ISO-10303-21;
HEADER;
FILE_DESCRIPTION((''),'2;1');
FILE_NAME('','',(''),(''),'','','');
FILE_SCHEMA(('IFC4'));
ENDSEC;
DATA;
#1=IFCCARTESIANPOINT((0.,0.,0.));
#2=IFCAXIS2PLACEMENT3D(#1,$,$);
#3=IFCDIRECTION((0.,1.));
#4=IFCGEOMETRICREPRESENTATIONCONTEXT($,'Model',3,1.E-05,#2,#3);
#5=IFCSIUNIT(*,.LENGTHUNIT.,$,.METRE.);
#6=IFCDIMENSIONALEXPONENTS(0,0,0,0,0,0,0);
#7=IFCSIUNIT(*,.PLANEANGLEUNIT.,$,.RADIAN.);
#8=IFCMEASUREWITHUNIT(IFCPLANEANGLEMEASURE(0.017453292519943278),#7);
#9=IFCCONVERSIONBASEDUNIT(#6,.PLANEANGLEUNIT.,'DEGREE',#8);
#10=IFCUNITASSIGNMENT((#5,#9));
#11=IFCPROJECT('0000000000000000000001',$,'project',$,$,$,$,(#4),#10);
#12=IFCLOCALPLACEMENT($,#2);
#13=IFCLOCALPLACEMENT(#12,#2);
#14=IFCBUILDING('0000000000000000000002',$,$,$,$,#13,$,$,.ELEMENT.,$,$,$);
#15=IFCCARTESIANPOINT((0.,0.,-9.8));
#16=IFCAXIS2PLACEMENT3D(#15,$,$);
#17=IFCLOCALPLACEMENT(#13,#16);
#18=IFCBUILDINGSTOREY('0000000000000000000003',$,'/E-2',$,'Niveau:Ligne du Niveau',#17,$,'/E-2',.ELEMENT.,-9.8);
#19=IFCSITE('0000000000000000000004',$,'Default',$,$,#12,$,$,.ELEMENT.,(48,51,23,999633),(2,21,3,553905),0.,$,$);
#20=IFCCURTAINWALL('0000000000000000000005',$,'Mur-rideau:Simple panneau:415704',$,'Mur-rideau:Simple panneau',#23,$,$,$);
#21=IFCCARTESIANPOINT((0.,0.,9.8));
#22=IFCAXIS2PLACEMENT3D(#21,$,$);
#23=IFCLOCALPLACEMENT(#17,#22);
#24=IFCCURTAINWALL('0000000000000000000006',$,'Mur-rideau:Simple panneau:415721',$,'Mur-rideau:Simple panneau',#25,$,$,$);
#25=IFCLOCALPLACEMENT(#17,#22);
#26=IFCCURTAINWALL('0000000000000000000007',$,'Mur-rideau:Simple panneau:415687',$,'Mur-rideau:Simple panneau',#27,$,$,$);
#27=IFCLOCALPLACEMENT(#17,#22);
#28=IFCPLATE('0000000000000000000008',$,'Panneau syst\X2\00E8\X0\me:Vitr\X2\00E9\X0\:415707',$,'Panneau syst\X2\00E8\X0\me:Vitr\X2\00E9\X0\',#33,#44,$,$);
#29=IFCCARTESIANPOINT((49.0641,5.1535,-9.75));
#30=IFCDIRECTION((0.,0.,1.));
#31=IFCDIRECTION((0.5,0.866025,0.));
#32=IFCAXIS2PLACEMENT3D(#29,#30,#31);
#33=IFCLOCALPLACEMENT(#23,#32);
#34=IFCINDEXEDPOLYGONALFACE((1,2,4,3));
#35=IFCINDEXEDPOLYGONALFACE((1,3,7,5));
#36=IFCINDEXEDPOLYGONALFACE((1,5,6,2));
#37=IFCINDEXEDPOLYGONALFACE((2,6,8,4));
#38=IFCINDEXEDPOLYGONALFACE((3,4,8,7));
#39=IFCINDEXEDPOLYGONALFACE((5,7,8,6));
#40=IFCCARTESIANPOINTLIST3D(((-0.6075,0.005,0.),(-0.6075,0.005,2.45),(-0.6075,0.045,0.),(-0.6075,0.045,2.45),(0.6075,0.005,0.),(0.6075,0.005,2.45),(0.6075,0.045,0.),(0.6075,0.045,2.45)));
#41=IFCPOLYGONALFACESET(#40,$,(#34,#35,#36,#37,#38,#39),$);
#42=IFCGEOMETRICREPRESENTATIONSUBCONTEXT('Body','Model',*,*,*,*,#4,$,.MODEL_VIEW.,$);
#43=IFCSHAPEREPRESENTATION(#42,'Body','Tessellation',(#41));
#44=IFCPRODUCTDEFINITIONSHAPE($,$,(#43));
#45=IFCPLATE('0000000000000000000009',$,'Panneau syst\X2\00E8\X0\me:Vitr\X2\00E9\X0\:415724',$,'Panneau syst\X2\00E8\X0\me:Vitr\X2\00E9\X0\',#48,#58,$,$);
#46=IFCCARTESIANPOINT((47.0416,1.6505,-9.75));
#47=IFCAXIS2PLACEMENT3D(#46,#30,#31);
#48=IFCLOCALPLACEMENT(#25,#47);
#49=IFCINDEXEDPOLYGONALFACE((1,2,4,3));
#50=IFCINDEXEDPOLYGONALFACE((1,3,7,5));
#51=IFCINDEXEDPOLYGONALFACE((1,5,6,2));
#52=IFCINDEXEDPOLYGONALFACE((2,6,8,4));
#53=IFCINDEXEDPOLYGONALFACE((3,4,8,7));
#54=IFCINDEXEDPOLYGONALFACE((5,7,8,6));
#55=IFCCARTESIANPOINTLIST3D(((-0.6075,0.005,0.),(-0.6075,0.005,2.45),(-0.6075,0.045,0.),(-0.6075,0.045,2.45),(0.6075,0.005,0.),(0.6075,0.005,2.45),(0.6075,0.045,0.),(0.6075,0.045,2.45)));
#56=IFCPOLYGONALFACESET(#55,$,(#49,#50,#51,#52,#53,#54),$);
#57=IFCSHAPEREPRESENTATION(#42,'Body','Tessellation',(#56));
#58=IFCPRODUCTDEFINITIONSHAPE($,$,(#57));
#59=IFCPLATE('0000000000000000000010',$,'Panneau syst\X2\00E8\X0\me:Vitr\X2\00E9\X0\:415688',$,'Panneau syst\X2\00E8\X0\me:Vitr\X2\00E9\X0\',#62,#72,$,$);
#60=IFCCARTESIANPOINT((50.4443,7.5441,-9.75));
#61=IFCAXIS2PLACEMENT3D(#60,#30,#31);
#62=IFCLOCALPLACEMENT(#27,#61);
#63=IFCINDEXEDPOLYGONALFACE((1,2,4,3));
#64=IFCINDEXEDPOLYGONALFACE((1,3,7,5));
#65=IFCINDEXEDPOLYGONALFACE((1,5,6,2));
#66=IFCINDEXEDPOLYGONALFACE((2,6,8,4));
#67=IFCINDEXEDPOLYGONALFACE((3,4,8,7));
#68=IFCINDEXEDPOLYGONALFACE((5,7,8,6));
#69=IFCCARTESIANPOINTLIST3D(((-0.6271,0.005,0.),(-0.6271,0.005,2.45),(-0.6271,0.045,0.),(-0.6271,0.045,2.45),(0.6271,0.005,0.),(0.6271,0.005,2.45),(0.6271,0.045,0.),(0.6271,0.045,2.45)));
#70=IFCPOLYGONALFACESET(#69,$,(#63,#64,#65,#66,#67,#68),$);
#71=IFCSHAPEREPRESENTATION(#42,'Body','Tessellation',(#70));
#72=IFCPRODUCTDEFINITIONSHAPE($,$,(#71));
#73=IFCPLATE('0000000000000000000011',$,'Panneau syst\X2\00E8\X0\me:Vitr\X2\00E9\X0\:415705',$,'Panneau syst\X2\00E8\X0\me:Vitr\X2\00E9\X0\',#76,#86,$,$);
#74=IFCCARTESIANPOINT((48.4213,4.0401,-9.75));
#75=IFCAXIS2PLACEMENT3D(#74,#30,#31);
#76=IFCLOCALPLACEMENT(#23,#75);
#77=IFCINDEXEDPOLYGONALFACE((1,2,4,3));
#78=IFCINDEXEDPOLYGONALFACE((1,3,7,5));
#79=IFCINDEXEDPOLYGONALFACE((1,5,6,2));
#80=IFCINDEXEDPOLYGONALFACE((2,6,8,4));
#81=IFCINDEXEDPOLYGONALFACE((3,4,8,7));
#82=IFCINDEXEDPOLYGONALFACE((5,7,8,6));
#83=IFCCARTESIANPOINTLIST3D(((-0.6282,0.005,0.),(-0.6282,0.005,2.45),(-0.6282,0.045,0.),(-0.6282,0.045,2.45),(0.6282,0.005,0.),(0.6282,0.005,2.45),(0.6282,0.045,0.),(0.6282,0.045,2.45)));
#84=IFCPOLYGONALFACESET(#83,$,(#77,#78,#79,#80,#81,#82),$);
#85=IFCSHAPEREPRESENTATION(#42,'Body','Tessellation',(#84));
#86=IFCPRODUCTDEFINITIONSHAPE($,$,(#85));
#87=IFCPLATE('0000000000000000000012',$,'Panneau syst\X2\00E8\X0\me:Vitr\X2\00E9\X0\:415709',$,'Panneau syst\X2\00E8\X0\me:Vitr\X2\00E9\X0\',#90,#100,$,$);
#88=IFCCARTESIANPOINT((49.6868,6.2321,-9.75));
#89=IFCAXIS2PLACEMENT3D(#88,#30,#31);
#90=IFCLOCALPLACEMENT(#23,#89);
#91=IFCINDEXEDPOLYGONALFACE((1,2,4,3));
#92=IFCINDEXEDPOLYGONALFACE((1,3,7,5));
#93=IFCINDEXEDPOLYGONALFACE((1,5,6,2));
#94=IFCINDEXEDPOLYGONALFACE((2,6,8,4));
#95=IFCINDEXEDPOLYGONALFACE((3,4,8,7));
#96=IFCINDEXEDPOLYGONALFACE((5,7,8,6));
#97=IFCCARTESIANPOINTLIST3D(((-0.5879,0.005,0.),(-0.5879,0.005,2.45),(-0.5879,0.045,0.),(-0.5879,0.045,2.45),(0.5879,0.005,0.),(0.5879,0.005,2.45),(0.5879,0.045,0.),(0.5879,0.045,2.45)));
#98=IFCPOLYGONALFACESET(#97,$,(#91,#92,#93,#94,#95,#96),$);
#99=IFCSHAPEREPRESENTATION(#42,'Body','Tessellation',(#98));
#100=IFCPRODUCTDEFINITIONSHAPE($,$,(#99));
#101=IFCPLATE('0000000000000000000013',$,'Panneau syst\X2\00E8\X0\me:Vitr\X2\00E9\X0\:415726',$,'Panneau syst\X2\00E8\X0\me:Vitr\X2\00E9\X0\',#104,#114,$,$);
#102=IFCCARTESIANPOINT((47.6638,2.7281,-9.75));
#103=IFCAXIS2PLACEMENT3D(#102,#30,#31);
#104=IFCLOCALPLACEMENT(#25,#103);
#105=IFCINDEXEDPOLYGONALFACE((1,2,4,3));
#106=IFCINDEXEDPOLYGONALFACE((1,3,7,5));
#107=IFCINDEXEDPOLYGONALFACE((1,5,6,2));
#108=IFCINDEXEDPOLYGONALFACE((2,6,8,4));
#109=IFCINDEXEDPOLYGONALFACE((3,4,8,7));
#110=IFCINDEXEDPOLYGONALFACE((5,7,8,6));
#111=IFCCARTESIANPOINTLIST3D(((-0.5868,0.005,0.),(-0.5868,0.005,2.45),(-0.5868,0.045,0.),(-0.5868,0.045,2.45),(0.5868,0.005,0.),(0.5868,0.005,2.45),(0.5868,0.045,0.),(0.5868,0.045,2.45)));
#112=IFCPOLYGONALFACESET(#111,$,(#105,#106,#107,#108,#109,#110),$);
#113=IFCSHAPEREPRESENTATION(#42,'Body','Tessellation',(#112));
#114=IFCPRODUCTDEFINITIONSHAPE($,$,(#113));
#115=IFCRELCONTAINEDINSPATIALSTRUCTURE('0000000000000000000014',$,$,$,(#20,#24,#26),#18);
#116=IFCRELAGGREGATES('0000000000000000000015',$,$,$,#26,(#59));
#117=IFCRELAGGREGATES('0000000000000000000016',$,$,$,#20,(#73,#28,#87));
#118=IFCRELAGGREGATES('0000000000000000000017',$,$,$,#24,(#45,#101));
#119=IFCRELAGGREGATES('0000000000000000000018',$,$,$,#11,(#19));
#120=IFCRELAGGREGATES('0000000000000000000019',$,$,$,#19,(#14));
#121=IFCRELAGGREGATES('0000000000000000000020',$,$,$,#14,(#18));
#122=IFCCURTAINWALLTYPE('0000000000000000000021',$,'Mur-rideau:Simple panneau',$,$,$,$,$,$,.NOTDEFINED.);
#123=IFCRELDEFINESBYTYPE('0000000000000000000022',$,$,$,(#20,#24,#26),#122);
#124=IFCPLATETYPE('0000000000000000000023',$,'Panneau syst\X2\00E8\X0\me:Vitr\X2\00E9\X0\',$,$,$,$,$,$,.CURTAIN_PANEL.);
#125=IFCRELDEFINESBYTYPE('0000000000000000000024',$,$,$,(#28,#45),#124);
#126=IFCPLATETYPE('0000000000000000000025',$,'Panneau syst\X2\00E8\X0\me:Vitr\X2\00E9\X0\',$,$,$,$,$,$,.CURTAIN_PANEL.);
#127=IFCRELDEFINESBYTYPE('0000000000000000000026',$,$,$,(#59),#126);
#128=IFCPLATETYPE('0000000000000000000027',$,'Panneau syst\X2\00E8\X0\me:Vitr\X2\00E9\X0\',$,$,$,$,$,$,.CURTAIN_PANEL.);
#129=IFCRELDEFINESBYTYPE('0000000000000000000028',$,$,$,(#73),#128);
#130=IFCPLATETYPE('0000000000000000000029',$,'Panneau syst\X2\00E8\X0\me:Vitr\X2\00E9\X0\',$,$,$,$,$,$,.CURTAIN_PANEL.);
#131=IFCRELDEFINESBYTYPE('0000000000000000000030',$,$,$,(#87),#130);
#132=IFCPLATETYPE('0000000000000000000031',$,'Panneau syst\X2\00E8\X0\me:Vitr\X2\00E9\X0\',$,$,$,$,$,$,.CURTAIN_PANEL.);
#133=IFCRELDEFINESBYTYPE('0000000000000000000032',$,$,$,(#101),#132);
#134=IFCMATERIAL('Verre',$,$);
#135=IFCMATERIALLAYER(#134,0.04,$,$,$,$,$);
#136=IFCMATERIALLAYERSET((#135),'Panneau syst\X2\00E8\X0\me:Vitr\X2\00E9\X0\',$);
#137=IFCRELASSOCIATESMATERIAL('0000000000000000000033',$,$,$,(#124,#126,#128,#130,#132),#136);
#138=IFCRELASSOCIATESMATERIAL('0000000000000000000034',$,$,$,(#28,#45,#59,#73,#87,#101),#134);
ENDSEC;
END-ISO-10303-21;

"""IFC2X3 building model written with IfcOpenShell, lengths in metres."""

from ifc_helpers import new_model, entity, si_unit, converted_unit, direction, frame, frame_2d, origin, place, context, subcontext, project, spatial, rectangle, extrude, source, transform, mapped, material, layer, layer_set, type_object, type_shapes, element, aggregate, save


model = new_model("IFC2X3")

# Units and contexts
model_context = context("Model", 3, precision=1e-05, world=origin(), true_north=direction((0.0, 1.0)))
body_context = subcontext(model_context, "Body", "Model", "MODEL_VIEW")
ifc_project = project(units=[si_unit("LENGTHUNIT", "METRE"), converted_unit("PLANEANGLEUNIT", "DEGREE", entity("IfcPlaneAngleMeasure", 0.017453292519943278), si_unit("PLANEANGLEUNIT", "RADIAN"), dimensions=[0, 0, 0, 0, 0, 0, 0])], contexts=[model_context])

# Site, building, storey
site_placement = place(None, origin())
site = spatial("IfcSite", under=ifc_project, at=site_placement, Name="Default", CompositionType="ELEMENT", RefLatitude=(48, 51, 23, 999633), RefLongitude=(2, 21, 3, 553905), RefElevation=0.0)
building_placement = place(site_placement, origin())
building = spatial("IfcBuilding", under=site, at=building_placement, CompositionType="ELEMENT")
storey_placement = place(building_placement, frame((0.0, 0.0, -9.8)))
storey = spatial("IfcBuildingStorey", under=building, at=storey_placement, Name="/E-2", ObjectType="Niveau:Ligne du Niveau", LongName="/E-2", CompositionType="ELEMENT", Elevation=-9.8)

# Curtain walls
curtain_wall_type = type_object("IfcCurtainWallType", Name="Mur-rideau:Simple panneau", PredefinedType="NOTDEFINED")
curtain_wall_1_placement = place(storey_placement, frame((0.0, 0.0, 9.8)))
curtain_wall_1 = element("IfcCurtainWall", 1, at=curtain_wall_1_placement, inside=storey, type_object=curtain_wall_type, Name="Mur-rideau:Simple panneau:415704", ObjectType="Mur-rideau:Simple panneau")
curtain_wall_2_placement = place(storey_placement, frame((0.0, 0.0, 9.8)))
curtain_wall_2 = element("IfcCurtainWall", 2, at=curtain_wall_2_placement, inside=storey, type_object=curtain_wall_type, Name="Mur-rideau:Simple panneau:415721", ObjectType="Mur-rideau:Simple panneau")

# Curtain wall
curtain_wall_3_placement = place(storey_placement, frame((0.0, 0.0, 9.8)))
curtain_wall_3 = element("IfcCurtainWall", 3, at=curtain_wall_3_placement, inside=storey, type_object=curtain_wall_type, Name="Mur-rideau:Simple panneau:415687", ObjectType="Mur-rideau:Simple panneau")

# Plates
ifc_material_1 = material(Name="Verre")
ifc_layer_1 = layer(ifc_material_1, 0.04)
ifc_layer_set_1 = layer_set([ifc_layer_1], Name="Panneau système:Vitré")
plate_type_1 = type_object("IfcPlateType", Name="Panneau système:Vitré", PredefinedType="CURTAIN_PANEL", material=ifc_layer_set_1)
shared_shape_1 = source(origin(), body_context, "Body", "SweptSolid", [
    extrude(rectangle(XDim=0.04, YDim=1.215, at=frame_2d((0.0, 0.0), x_axis=(1.0, 0.0))), frame((0.0, 0.025, 0.0), z_axis=(0.0, 0.0, 1.0), x_axis=(0.0, 1.0, 0.0)), (0.0, 0.0, 1.0), 2.45),
])
type_shapes(plate_type_1, [shared_shape_1])
plate_1_placement = place(curtain_wall_1_placement, frame((49.0641, 5.1535, -9.75), z_axis=(0.0, 0.0, 1.0), x_axis=(0.5, 0.866025, 0.0)))
plate_1 = element("IfcPlate", 4, at=plate_1_placement, type_object=plate_type_1, material=ifc_material_1, Name="Panneau système:Vitré:415707", ObjectType="Panneau système:Vitré", context=body_context, shape_type="MappedRepresentation", body=[
    mapped(shared_shape_1, transform((0.0, 0.0, 0.0), scale=1.0)),
])
plate_2_placement = place(curtain_wall_2_placement, frame((47.0416, 1.6505, -9.75), z_axis=(0.0, 0.0, 1.0), x_axis=(0.5, 0.866025, 0.0)))
plate_2 = element("IfcPlate", 5, at=plate_2_placement, type_object=plate_type_1, material=ifc_material_1, Name="Panneau système:Vitré:415724", ObjectType="Panneau système:Vitré", context=body_context, shape_type="MappedRepresentation", body=[
    mapped(shared_shape_1, transform((0.0, 0.0, 0.0), scale=1.0)),
])
plate_type_2 = type_object("IfcPlateType", Name="Panneau système:Vitré", PredefinedType="CURTAIN_PANEL", material=ifc_layer_set_1)
shared_shape_2 = source(origin(), body_context, "Body", "SweptSolid", [
    extrude(rectangle(XDim=0.04, YDim=1.2542, at=frame_2d((0.0, 0.0), x_axis=(1.0, 0.0))), frame((0.0, 0.025, 0.0), z_axis=(0.0, 0.0, 1.0), x_axis=(0.0, 1.0, 0.0)), (0.0, 0.0, 1.0), 2.45),
])
type_shapes(plate_type_2, [shared_shape_2])
plate_3_placement = place(curtain_wall_3_placement, frame((50.4443, 7.5441, -9.75), z_axis=(0.0, 0.0, 1.0), x_axis=(0.5, 0.866025, 0.0)))
plate_3 = element("IfcPlate", 6, at=plate_3_placement, type_object=plate_type_2, material=ifc_material_1, Name="Panneau système:Vitré:415688", ObjectType="Panneau système:Vitré", context=body_context, shape_type="MappedRepresentation", body=[
    mapped(shared_shape_2, transform((0.0, 0.0, 0.0), scale=1.0)),
])
aggregate(curtain_wall_3, [plate_3])
plate_type_3 = type_object("IfcPlateType", Name="Panneau système:Vitré", PredefinedType="CURTAIN_PANEL", material=ifc_layer_set_1)
shared_shape_3 = source(origin(), body_context, "Body", "SweptSolid", [
    extrude(rectangle(XDim=0.04, YDim=1.2564, at=frame_2d((0.0, 0.0), x_axis=(1.0, 0.0))), frame((0.0, 0.025, 0.0), z_axis=(0.0, 0.0, 1.0), x_axis=(0.0, 1.0, 0.0)), (0.0, 0.0, 1.0), 2.45),
])
type_shapes(plate_type_3, [shared_shape_3])
plate_4_placement = place(curtain_wall_1_placement, frame((48.4213, 4.0401, -9.75), z_axis=(0.0, 0.0, 1.0), x_axis=(0.5, 0.866025, 0.0)))
plate_4 = element("IfcPlate", 7, at=plate_4_placement, type_object=plate_type_3, material=ifc_material_1, Name="Panneau système:Vitré:415705", ObjectType="Panneau système:Vitré", context=body_context, shape_type="MappedRepresentation", body=[
    mapped(shared_shape_3, transform((0.0, 0.0, 0.0), scale=1.0)),
])
plate_type_4 = type_object("IfcPlateType", Name="Panneau système:Vitré", PredefinedType="CURTAIN_PANEL", material=ifc_layer_set_1)
shared_shape_4 = source(origin(), body_context, "Body", "SweptSolid", [
    extrude(rectangle(XDim=0.04, YDim=1.1758, at=frame_2d((0.0, 0.0), x_axis=(1.0, 0.0))), frame((0.0, 0.025, 0.0), z_axis=(0.0, 0.0, 1.0), x_axis=(0.0, 1.0, 0.0)), (0.0, 0.0, 1.0), 2.45),
])
type_shapes(plate_type_4, [shared_shape_4])
plate_5_placement = place(curtain_wall_1_placement, frame((49.6868, 6.2321, -9.75), z_axis=(0.0, 0.0, 1.0), x_axis=(0.5, 0.866025, 0.0)))
plate_5 = element("IfcPlate", 8, at=plate_5_placement, type_object=plate_type_4, material=ifc_material_1, Name="Panneau système:Vitré:415709", ObjectType="Panneau système:Vitré", context=body_context, shape_type="MappedRepresentation", body=[
    mapped(shared_shape_4, transform((0.0, 0.0, 0.0), scale=1.0)),
])
aggregate(curtain_wall_1, [plate_4, plate_1, plate_5])
plate_type_5 = type_object("IfcPlateType", Name="Panneau système:Vitré", PredefinedType="CURTAIN_PANEL", material=ifc_layer_set_1)
shared_shape_5 = source(origin(), body_context, "Body", "SweptSolid", [
    extrude(rectangle(XDim=0.04, YDim=1.1736, at=frame_2d((0.0, 0.0), x_axis=(1.0, 0.0))), frame((0.0, 0.025, 0.0), z_axis=(0.0, 0.0, 1.0), x_axis=(0.0, 1.0, 0.0)), (0.0, 0.0, 1.0), 2.45),
])
type_shapes(plate_type_5, [shared_shape_5])
plate_6_placement = place(curtain_wall_2_placement, frame((47.6638, 2.7281, -9.75), z_axis=(0.0, 0.0, 1.0), x_axis=(0.5, 0.866025, 0.0)))
plate_6 = element("IfcPlate", 9, at=plate_6_placement, type_object=plate_type_5, material=ifc_material_1, Name="Panneau système:Vitré:415726", ObjectType="Panneau système:Vitré", context=body_context, shape_type="MappedRepresentation", body=[
    mapped(shared_shape_5, transform((0.0, 0.0, 0.0), scale=1.0)),
])
aggregate(curtain_wall_2, [plate_2, plate_6])

save(model, "model.ifc")
